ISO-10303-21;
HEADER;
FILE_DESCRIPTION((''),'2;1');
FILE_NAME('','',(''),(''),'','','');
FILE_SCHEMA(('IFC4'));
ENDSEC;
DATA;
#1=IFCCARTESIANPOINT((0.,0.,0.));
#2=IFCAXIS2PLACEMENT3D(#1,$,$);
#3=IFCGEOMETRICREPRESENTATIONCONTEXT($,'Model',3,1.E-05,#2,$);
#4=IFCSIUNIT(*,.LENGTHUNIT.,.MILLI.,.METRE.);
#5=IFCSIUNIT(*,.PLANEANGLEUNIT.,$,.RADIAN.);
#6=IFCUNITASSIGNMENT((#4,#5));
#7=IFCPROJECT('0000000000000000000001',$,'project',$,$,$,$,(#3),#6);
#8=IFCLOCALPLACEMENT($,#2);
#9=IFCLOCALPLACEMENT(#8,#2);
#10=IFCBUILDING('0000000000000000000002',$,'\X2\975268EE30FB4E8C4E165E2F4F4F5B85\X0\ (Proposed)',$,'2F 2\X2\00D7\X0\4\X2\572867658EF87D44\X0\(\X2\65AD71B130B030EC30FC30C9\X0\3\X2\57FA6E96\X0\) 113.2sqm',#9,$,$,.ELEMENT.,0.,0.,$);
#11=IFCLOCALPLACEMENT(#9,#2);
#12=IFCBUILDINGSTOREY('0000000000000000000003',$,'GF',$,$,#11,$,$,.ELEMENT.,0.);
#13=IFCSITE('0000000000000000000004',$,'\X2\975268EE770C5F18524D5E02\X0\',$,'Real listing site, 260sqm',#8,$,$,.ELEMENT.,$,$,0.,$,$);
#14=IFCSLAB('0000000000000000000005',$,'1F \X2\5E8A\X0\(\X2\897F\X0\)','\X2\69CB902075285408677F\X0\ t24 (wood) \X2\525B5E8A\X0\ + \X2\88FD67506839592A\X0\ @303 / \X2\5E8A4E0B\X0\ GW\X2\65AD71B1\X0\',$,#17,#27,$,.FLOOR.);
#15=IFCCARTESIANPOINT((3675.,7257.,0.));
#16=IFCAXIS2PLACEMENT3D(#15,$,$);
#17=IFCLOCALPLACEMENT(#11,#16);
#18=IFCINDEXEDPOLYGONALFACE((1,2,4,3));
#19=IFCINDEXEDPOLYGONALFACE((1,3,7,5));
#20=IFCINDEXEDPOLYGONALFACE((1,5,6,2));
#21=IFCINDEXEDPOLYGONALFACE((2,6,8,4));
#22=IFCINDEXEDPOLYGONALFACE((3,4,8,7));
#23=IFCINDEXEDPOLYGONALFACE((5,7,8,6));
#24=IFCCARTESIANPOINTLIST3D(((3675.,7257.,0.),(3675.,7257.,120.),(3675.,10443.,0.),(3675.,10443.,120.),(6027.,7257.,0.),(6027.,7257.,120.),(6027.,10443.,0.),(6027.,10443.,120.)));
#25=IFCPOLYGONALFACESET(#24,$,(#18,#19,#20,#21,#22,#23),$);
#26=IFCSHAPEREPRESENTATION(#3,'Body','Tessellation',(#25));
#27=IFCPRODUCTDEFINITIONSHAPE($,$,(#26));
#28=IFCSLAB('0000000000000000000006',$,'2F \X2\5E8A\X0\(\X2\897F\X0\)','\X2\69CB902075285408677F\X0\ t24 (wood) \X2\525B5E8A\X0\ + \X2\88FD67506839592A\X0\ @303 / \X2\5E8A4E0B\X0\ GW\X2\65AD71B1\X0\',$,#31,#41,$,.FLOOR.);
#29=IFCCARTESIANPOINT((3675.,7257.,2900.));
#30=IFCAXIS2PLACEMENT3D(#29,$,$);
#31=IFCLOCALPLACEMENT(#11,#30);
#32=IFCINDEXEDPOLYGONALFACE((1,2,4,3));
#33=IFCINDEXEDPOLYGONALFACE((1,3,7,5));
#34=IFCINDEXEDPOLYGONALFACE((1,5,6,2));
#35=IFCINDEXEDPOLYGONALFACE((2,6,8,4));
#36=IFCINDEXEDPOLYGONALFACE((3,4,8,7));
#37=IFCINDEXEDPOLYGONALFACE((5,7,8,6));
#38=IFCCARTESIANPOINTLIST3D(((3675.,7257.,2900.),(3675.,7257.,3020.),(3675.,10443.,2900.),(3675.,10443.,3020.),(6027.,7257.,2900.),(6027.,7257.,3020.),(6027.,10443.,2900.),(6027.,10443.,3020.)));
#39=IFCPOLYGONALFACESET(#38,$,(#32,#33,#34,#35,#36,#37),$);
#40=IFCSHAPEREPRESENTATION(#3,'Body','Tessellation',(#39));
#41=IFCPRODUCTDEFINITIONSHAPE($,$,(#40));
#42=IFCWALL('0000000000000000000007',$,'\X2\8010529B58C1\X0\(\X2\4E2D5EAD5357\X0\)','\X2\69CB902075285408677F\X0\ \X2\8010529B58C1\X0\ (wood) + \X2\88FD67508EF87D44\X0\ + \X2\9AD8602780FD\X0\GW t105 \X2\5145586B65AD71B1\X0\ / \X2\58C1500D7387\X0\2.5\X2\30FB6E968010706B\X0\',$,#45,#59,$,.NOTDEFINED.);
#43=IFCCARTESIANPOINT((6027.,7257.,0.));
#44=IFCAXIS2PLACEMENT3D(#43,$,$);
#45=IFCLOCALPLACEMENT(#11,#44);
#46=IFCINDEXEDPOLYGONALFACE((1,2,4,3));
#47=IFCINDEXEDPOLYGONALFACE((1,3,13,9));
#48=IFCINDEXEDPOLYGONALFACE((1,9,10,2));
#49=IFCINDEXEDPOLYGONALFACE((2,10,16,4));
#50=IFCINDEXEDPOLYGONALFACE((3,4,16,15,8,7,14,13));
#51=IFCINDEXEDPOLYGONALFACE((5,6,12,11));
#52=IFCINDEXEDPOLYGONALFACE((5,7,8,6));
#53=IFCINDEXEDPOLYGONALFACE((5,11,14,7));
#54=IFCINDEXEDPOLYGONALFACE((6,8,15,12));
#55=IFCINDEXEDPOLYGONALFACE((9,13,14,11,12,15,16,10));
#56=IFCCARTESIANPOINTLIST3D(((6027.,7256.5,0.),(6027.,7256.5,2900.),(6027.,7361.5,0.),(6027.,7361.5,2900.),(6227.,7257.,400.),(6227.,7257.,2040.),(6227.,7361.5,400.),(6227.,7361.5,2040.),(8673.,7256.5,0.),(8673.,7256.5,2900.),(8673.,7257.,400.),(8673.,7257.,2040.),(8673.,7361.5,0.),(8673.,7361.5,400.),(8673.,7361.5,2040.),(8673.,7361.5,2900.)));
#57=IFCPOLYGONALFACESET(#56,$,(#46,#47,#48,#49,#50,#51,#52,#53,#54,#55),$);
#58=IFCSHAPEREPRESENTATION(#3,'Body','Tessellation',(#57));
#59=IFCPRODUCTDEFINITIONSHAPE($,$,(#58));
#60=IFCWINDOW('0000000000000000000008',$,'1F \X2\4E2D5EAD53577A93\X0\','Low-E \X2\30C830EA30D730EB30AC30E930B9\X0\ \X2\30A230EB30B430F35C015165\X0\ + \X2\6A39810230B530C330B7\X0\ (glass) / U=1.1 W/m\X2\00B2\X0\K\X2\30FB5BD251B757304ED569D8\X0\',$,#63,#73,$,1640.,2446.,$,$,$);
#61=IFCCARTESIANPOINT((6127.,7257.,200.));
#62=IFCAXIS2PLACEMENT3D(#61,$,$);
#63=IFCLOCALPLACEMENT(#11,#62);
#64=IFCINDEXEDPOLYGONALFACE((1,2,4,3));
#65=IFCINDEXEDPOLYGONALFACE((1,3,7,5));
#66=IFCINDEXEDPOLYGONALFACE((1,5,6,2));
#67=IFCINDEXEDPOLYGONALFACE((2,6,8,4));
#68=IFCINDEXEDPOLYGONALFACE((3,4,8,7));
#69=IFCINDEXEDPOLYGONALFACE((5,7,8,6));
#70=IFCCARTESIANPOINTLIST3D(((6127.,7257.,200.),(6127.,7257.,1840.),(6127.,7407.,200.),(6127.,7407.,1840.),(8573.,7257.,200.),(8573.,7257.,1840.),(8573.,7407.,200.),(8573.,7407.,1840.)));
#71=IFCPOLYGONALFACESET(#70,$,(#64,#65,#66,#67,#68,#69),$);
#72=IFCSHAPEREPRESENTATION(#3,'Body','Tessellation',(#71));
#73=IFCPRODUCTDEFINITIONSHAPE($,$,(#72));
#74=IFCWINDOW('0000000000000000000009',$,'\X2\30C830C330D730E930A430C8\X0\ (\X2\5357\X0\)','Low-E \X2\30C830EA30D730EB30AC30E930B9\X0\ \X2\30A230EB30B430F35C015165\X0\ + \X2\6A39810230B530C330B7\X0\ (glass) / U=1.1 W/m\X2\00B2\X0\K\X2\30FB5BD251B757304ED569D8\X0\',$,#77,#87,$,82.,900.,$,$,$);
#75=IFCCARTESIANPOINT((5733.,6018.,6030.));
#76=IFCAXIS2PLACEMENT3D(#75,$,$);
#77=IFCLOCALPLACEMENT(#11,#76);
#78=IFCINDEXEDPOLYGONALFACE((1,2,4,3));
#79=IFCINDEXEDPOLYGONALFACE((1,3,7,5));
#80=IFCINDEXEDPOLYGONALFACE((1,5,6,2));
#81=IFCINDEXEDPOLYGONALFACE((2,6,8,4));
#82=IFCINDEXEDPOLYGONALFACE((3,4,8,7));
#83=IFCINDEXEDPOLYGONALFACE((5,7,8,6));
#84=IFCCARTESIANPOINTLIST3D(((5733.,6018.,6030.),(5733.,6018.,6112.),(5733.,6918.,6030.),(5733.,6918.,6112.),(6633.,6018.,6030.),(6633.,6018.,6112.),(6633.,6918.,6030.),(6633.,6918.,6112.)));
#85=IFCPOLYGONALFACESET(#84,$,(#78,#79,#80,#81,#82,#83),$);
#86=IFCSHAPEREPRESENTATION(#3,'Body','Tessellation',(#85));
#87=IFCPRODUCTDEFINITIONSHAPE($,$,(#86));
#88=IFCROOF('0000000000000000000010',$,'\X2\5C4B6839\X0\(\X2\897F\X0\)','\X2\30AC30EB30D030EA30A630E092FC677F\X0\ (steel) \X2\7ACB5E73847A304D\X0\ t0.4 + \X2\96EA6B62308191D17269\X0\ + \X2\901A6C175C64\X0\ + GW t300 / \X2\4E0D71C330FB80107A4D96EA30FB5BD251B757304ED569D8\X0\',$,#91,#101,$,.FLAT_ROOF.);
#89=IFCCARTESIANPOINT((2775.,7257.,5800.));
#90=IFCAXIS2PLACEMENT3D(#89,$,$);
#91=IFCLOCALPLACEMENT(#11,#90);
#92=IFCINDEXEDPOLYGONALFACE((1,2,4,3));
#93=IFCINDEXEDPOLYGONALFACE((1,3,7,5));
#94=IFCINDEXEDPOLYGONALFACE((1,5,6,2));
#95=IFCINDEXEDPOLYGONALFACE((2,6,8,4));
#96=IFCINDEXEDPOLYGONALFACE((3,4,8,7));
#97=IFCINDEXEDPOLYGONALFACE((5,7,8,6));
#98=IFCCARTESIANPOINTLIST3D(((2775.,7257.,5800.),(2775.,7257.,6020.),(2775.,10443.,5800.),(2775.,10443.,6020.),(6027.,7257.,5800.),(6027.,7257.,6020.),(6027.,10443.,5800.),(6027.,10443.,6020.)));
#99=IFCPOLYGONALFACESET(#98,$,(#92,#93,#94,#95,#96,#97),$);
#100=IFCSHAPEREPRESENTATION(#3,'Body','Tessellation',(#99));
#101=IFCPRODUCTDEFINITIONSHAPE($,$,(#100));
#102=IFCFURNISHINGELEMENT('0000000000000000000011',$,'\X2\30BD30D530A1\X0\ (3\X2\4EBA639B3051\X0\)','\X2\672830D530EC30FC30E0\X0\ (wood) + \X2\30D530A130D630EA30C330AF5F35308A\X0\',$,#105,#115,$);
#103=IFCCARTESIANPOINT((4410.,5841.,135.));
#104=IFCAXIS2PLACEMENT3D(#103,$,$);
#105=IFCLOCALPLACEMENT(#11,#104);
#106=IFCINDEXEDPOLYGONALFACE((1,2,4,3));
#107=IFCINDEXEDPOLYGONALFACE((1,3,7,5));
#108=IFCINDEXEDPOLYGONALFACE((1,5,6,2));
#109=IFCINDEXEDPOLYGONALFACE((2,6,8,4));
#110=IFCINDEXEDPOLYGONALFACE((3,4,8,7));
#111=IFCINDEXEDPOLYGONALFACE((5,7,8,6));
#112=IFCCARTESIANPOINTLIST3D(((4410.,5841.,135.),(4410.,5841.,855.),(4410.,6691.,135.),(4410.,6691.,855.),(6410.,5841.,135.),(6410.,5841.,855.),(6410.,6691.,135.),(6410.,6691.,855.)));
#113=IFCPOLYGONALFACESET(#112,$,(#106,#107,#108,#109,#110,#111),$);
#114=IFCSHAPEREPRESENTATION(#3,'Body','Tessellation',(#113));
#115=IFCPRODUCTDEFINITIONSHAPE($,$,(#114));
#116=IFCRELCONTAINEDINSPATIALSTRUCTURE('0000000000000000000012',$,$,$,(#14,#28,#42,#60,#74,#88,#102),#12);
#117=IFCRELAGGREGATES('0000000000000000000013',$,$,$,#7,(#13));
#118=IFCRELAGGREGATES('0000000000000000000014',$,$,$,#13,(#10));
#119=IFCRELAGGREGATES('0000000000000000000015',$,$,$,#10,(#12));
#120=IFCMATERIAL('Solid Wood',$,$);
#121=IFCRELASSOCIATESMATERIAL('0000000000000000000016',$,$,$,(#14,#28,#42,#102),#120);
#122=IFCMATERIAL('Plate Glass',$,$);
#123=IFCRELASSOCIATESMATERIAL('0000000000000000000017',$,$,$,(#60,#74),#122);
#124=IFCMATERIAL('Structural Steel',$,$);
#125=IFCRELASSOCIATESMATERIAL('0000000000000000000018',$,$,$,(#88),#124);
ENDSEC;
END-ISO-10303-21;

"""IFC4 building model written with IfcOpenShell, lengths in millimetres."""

from ifc_helpers import new_model, si_unit, frame, frame_2d, origin, place, context, project, spatial, rectangle, extrude, material, element, fill, save


model = new_model("IFC4")

# Units and contexts
model_context = context("Model", 3, precision=1e-05, world=origin())
ifc_project = project(units=[si_unit("LENGTHUNIT", "METRE", prefix="MILLI"), si_unit("PLANEANGLEUNIT", "RADIAN")], contexts=[model_context])

# Site, building, storey
site_placement = place(None, origin())
site = spatial("IfcSite", under=ifc_project, at=site_placement, Name="青森県弘前市", ObjectType="Real listing site, 260sqm", CompositionType="ELEMENT", RefElevation=0.0)
building_placement = place(site_placement, origin())
building = spatial("IfcBuilding", under=site, at=building_placement, Name="青森・二世帯住宅 (Proposed)", ObjectType="2F 2×4在来軸組(断熱グレード3基準) 113.2sqm", CompositionType="ELEMENT", ElevationOfRefHeight=0.0, ElevationOfTerrain=0.0)
storey_placement = place(building_placement, origin())
storey = spatial("IfcBuildingStorey", under=building, at=storey_placement, Name="GF", CompositionType="ELEMENT", Elevation=0.0)

# Shared definitions
ifc_material_1 = material(Name="Solid Wood")

# Slabs
slab_1_placement = place(storey_placement, frame((3675.0, 7257.0, 0.0)))
element("IfcSlab", 1, at=slab_1_placement, inside=storey, material=ifc_material_1, Name="1F 床(西)", Description="構造用合板 t24 (wood) 剛床 + 製材根太 @303 / 床下 GW断熱", PredefinedType="FLOOR", context=model_context, shape_type="SweptSolid", body=[
    extrude(rectangle(XDim=2352.0, YDim=3186.0, at=frame_2d((1176.0, 1593.0))), frame((3675.0, 7257.0, 0.0)), (0.0, 0.0, 1.0), 120.0),
])
slab_2_placement = place(storey_placement, frame((3675.0, 7257.0, 2900.0)))
element("IfcSlab", 2, at=slab_2_placement, inside=storey, material=ifc_material_1, Name="2F 床(西)", Description="構造用合板 t24 (wood) 剛床 + 製材根太 @303 / 床下 GW断熱", PredefinedType="FLOOR", context=model_context, shape_type="SweptSolid", body=[
    extrude(rectangle(XDim=2352.0, YDim=3186.0, at=frame_2d((1176.0, 1593.0))), frame((3675.0, 7257.0, 2900.0)), (0.0, 0.0, 1.0), 120.0),
])

# Wall, opening, window
wall_placement = place(storey_placement, frame((6027.0, 7257.0, 0.0)))
wall = element("IfcWall", 3, at=wall_placement, inside=storey, material=ifc_material_1, Name="耐力壁(中庭南)", Description="構造用合板 耐力壁 (wood) + 製材軸組 + 高性能GW t105 充填断熱 / 壁倍率2.5・準耐火", PredefinedType="NOTDEFINED", context=model_context, shape_type="SweptSolid", body=[
    extrude(rectangle(XDim=2646.0, YDim=105.0, at=frame_2d((1323.0, 52.0))), frame((6027.0, 7257.0, 0.0)), (0.0, 0.0, 1.0), 2900.0),
])
opening_placement = place(storey_placement, frame((6127.0, 7257.0, 200.0)))
opening = element("IfcOpeningElement", 4, at=opening_placement, cuts=wall, PredefinedType="NOTDEFINED", context=model_context, shape_type="SweptSolid", body=[
    extrude(rectangle(XDim=2446.0, YDim=150.0, at=frame_2d((1223.0, 75.0))), frame((6127.0, 7257.0, 200.0)), (0.0, 0.0, 1.0), 1640.0),
])
ifc_material_2 = material(Name="Plate Glass")
window_1_placement = place(storey_placement, frame((6127.0, 7257.0, 200.0)))
window_1 = element("IfcWindow", 5, at=window_1_placement, inside=storey, material=ifc_material_2, Name="1F 中庭南窓", Description="Low-E トリプルガラス アルゴン封入 + 樹脂サッシ (glass) / U=1.1 W/m²K・寒冷地仕様", OverallHeight=1640.0, OverallWidth=2446.0, context=model_context, shape_type="SweptSolid", body=[
    extrude(rectangle(XDim=2446.0, YDim=150.0, at=frame_2d((1223.0, 75.0))), frame((6127.0, 7257.0, 200.0)), (0.0, 0.0, 1.0), 1640.0),
])
fill(opening, window_1)

# Window
window_2_placement = place(storey_placement, frame((5733.0, 6018.0, 6030.0)))
element("IfcWindow", 6, at=window_2_placement, inside=storey, material=ifc_material_2, Name="トップライト (南)", Description="Low-E トリプルガラス アルゴン封入 + 樹脂サッシ (glass) / U=1.1 W/m²K・寒冷地仕様", OverallHeight=82.0, OverallWidth=900.0, context=model_context, shape_type="SweptSolid", body=[
    extrude(rectangle(XDim=900.0, YDim=900.0, at=frame_2d((450.0, 450.0))), frame((5733.0, 6018.0, 6030.0)), (0.0, 0.0, 1.0), 82.0),
])

# Roof
ifc_material_3 = material(Name="Structural Steel")
for number, where, name in (
    (7, (2775.0, 7257.0, 5800.0), "屋根(西)"),
):
    element("IfcRoof", number, at=place(storey_placement, frame(where)), inside=storey, material=ifc_material_3, Name=name, Description="ガルバリウム鋼板 (steel) 立平葺き t0.4 + 雪止め金物 + 通気層 + GW t300 / 不燃・耐積雪・寒冷地仕様", PredefinedType="FLAT_ROOF", context=model_context, shape_type="SweptSolid", body=[
        extrude(rectangle(XDim=3252.0, YDim=3186.0, at=frame_2d((1626.0, 1593.0))), frame((2775.0, 7257.0, 5800.0)), (0.0, 0.0, 1.0), 220.0),
    ])

# Furnishing element
furnishing_placement = place(storey_placement, frame((4410.0, 5841.0, 135.0)))
element("IfcFurnishingElement", 8, at=furnishing_placement, inside=storey, material=ifc_material_1, Name="ソファ (3人掛け)", Description="木フレーム (wood) + ファブリック張り", context=model_context, shape_type="SweptSolid", body=[
    extrude(rectangle(XDim=2000.0, YDim=850.0, at=frame_2d((1000.0, 425.0))), frame((4410.0, 5841.0, 135.0)), (0.0, 0.0, 1.0), 720.0),
])

save(model, "model.ifc")
